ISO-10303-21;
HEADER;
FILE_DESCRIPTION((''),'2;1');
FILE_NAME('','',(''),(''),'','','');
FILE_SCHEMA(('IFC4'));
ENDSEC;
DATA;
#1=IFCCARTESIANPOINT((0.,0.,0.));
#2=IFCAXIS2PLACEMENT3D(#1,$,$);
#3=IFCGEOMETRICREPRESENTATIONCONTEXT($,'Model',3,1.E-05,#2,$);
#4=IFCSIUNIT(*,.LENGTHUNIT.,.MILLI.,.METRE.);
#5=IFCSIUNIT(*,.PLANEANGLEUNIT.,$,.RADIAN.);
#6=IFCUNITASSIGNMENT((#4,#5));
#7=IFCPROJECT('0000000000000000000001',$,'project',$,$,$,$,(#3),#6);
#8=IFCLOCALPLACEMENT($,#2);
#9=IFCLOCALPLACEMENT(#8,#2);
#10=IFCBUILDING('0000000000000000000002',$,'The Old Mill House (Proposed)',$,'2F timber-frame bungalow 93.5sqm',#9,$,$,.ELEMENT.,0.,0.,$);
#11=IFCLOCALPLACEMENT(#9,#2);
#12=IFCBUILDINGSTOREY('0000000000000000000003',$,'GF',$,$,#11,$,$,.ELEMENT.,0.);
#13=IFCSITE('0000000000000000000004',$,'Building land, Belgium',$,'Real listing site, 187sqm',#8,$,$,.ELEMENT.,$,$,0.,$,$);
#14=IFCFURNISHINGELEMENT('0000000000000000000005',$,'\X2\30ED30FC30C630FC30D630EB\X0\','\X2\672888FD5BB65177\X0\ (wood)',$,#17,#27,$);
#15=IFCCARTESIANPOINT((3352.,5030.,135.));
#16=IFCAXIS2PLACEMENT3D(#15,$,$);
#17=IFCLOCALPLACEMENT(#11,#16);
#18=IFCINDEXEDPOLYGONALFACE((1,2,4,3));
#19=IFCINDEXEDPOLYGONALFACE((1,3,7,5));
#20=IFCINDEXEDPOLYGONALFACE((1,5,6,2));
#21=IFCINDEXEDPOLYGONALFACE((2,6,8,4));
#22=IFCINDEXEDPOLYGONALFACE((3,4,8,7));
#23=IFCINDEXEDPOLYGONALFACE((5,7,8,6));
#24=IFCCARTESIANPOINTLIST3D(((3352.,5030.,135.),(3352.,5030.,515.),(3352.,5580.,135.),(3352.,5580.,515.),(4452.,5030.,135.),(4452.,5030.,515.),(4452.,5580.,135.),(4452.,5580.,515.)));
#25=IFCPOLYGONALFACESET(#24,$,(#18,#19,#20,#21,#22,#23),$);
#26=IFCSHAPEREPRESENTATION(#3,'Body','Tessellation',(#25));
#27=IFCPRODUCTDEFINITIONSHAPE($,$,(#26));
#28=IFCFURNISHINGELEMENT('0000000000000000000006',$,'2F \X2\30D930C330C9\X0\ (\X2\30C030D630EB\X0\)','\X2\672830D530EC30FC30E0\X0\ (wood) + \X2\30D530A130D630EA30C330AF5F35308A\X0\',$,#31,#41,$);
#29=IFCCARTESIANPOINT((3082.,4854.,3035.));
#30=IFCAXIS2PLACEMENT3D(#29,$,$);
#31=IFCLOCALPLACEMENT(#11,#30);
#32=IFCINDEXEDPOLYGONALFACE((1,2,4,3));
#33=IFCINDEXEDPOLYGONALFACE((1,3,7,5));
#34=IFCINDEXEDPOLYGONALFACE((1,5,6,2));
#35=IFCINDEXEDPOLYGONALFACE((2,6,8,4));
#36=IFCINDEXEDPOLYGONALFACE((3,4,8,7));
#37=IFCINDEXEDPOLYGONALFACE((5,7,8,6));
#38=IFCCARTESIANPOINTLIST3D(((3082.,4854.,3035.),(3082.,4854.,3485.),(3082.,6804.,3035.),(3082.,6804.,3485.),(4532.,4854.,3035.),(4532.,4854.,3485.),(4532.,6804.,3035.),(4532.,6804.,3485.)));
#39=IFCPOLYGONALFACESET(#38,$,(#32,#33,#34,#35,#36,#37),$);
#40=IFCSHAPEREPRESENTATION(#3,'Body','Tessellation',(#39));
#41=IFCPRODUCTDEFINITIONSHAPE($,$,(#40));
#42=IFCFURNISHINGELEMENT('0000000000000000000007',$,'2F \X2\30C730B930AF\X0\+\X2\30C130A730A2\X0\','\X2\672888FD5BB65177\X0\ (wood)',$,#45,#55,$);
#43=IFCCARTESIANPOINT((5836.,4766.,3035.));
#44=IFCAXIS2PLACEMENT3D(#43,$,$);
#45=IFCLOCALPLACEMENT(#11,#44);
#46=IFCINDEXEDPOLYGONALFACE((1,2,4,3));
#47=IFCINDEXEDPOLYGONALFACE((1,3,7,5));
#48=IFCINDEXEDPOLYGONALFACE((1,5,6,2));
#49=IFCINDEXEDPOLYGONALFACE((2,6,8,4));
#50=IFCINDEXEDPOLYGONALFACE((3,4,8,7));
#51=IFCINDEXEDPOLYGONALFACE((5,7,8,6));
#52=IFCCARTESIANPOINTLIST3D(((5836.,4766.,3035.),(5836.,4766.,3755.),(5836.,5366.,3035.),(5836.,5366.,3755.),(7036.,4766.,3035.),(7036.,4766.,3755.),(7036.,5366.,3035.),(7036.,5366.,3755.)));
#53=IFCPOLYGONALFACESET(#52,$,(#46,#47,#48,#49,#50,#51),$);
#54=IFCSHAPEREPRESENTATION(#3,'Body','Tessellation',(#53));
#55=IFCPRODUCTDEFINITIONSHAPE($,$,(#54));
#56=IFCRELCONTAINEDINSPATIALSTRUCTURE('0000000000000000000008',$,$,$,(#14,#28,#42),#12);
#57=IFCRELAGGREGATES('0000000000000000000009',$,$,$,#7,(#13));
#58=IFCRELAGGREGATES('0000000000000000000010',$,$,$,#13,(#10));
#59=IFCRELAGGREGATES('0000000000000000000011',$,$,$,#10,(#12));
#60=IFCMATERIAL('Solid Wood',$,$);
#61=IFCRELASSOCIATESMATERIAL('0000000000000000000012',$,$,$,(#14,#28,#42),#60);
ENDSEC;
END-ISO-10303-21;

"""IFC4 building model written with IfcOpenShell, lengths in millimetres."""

from ifc_helpers import new_model, si_unit, frame, frame_2d, origin, place, context, project, spatial, rectangle, extrude, material, element, save


model = new_model("IFC4")

# Units and contexts
model_context = context("Model", 3, precision=1e-05, world=origin())
ifc_project = project(units=[si_unit("LENGTHUNIT", "METRE", prefix="MILLI"), si_unit("PLANEANGLEUNIT", "RADIAN")], contexts=[model_context])

# Site, building, storey
site_placement = place(None, origin())
site = spatial("IfcSite", under=ifc_project, at=site_placement, Name="Building land, Belgium", ObjectType="Real listing site, 187sqm", CompositionType="ELEMENT", RefElevation=0.0)
building_placement = place(site_placement, origin())
building = spatial("IfcBuilding", under=site, at=building_placement, Name="The Old Mill House (Proposed)", ObjectType="2F timber-frame bungalow 93.5sqm", CompositionType="ELEMENT", ElevationOfRefHeight=0.0, ElevationOfTerrain=0.0)
storey_placement = place(building_placement, origin())
storey = spatial("IfcBuildingStorey", under=building, at=storey_placement, Name="GF", CompositionType="ELEMENT", Elevation=0.0)

# Shared definitions
ifc_material_1 = material(Name="Solid Wood")

# Furnishing elements
furnishing_1_placement = place(storey_placement, frame((3352.0, 5030.0, 135.0)))
element("IfcFurnishingElement", 1, at=furnishing_1_placement, inside=storey, material=ifc_material_1, Name="ローテーブル", Description="木製家具 (wood)", context=model_context, shape_type="SweptSolid", body=[
    extrude(rectangle(XDim=1100.0, YDim=550.0, at=frame_2d((550.0, 275.0))), frame((3352.0, 5030.0, 135.0)), (0.0, 0.0, 1.0), 380.0),
])
furnishing_2_placement = place(storey_placement, frame((3082.0, 4854.0, 3035.0)))
element("IfcFurnishingElement", 2, at=furnishing_2_placement, inside=storey, material=ifc_material_1, Name="2F ベッド (ダブル)", Description="木フレーム (wood) + ファブリック張り", context=model_context, shape_type="SweptSolid", body=[
    extrude(rectangle(XDim=1450.0, YDim=1950.0, at=frame_2d((725.0, 975.0))), frame((3082.0, 4854.0, 3035.0)), (0.0, 0.0, 1.0), 450.0),
])
furnishing_3_placement = place(storey_placement, frame((5836.0, 4766.0, 3035.0)))
element("IfcFurnishingElement", 3, at=furnishing_3_placement, inside=storey, material=ifc_material_1, Name="2F デスク+チェア", Description="木製家具 (wood)", context=model_context, shape_type="SweptSolid", body=[
    extrude(rectangle(XDim=1200.0, YDim=600.0, at=frame_2d((600.0, 300.0))), frame((5836.0, 4766.0, 3035.0)), (0.0, 0.0, 1.0), 720.0),
])

save(model, "model.ifc")
